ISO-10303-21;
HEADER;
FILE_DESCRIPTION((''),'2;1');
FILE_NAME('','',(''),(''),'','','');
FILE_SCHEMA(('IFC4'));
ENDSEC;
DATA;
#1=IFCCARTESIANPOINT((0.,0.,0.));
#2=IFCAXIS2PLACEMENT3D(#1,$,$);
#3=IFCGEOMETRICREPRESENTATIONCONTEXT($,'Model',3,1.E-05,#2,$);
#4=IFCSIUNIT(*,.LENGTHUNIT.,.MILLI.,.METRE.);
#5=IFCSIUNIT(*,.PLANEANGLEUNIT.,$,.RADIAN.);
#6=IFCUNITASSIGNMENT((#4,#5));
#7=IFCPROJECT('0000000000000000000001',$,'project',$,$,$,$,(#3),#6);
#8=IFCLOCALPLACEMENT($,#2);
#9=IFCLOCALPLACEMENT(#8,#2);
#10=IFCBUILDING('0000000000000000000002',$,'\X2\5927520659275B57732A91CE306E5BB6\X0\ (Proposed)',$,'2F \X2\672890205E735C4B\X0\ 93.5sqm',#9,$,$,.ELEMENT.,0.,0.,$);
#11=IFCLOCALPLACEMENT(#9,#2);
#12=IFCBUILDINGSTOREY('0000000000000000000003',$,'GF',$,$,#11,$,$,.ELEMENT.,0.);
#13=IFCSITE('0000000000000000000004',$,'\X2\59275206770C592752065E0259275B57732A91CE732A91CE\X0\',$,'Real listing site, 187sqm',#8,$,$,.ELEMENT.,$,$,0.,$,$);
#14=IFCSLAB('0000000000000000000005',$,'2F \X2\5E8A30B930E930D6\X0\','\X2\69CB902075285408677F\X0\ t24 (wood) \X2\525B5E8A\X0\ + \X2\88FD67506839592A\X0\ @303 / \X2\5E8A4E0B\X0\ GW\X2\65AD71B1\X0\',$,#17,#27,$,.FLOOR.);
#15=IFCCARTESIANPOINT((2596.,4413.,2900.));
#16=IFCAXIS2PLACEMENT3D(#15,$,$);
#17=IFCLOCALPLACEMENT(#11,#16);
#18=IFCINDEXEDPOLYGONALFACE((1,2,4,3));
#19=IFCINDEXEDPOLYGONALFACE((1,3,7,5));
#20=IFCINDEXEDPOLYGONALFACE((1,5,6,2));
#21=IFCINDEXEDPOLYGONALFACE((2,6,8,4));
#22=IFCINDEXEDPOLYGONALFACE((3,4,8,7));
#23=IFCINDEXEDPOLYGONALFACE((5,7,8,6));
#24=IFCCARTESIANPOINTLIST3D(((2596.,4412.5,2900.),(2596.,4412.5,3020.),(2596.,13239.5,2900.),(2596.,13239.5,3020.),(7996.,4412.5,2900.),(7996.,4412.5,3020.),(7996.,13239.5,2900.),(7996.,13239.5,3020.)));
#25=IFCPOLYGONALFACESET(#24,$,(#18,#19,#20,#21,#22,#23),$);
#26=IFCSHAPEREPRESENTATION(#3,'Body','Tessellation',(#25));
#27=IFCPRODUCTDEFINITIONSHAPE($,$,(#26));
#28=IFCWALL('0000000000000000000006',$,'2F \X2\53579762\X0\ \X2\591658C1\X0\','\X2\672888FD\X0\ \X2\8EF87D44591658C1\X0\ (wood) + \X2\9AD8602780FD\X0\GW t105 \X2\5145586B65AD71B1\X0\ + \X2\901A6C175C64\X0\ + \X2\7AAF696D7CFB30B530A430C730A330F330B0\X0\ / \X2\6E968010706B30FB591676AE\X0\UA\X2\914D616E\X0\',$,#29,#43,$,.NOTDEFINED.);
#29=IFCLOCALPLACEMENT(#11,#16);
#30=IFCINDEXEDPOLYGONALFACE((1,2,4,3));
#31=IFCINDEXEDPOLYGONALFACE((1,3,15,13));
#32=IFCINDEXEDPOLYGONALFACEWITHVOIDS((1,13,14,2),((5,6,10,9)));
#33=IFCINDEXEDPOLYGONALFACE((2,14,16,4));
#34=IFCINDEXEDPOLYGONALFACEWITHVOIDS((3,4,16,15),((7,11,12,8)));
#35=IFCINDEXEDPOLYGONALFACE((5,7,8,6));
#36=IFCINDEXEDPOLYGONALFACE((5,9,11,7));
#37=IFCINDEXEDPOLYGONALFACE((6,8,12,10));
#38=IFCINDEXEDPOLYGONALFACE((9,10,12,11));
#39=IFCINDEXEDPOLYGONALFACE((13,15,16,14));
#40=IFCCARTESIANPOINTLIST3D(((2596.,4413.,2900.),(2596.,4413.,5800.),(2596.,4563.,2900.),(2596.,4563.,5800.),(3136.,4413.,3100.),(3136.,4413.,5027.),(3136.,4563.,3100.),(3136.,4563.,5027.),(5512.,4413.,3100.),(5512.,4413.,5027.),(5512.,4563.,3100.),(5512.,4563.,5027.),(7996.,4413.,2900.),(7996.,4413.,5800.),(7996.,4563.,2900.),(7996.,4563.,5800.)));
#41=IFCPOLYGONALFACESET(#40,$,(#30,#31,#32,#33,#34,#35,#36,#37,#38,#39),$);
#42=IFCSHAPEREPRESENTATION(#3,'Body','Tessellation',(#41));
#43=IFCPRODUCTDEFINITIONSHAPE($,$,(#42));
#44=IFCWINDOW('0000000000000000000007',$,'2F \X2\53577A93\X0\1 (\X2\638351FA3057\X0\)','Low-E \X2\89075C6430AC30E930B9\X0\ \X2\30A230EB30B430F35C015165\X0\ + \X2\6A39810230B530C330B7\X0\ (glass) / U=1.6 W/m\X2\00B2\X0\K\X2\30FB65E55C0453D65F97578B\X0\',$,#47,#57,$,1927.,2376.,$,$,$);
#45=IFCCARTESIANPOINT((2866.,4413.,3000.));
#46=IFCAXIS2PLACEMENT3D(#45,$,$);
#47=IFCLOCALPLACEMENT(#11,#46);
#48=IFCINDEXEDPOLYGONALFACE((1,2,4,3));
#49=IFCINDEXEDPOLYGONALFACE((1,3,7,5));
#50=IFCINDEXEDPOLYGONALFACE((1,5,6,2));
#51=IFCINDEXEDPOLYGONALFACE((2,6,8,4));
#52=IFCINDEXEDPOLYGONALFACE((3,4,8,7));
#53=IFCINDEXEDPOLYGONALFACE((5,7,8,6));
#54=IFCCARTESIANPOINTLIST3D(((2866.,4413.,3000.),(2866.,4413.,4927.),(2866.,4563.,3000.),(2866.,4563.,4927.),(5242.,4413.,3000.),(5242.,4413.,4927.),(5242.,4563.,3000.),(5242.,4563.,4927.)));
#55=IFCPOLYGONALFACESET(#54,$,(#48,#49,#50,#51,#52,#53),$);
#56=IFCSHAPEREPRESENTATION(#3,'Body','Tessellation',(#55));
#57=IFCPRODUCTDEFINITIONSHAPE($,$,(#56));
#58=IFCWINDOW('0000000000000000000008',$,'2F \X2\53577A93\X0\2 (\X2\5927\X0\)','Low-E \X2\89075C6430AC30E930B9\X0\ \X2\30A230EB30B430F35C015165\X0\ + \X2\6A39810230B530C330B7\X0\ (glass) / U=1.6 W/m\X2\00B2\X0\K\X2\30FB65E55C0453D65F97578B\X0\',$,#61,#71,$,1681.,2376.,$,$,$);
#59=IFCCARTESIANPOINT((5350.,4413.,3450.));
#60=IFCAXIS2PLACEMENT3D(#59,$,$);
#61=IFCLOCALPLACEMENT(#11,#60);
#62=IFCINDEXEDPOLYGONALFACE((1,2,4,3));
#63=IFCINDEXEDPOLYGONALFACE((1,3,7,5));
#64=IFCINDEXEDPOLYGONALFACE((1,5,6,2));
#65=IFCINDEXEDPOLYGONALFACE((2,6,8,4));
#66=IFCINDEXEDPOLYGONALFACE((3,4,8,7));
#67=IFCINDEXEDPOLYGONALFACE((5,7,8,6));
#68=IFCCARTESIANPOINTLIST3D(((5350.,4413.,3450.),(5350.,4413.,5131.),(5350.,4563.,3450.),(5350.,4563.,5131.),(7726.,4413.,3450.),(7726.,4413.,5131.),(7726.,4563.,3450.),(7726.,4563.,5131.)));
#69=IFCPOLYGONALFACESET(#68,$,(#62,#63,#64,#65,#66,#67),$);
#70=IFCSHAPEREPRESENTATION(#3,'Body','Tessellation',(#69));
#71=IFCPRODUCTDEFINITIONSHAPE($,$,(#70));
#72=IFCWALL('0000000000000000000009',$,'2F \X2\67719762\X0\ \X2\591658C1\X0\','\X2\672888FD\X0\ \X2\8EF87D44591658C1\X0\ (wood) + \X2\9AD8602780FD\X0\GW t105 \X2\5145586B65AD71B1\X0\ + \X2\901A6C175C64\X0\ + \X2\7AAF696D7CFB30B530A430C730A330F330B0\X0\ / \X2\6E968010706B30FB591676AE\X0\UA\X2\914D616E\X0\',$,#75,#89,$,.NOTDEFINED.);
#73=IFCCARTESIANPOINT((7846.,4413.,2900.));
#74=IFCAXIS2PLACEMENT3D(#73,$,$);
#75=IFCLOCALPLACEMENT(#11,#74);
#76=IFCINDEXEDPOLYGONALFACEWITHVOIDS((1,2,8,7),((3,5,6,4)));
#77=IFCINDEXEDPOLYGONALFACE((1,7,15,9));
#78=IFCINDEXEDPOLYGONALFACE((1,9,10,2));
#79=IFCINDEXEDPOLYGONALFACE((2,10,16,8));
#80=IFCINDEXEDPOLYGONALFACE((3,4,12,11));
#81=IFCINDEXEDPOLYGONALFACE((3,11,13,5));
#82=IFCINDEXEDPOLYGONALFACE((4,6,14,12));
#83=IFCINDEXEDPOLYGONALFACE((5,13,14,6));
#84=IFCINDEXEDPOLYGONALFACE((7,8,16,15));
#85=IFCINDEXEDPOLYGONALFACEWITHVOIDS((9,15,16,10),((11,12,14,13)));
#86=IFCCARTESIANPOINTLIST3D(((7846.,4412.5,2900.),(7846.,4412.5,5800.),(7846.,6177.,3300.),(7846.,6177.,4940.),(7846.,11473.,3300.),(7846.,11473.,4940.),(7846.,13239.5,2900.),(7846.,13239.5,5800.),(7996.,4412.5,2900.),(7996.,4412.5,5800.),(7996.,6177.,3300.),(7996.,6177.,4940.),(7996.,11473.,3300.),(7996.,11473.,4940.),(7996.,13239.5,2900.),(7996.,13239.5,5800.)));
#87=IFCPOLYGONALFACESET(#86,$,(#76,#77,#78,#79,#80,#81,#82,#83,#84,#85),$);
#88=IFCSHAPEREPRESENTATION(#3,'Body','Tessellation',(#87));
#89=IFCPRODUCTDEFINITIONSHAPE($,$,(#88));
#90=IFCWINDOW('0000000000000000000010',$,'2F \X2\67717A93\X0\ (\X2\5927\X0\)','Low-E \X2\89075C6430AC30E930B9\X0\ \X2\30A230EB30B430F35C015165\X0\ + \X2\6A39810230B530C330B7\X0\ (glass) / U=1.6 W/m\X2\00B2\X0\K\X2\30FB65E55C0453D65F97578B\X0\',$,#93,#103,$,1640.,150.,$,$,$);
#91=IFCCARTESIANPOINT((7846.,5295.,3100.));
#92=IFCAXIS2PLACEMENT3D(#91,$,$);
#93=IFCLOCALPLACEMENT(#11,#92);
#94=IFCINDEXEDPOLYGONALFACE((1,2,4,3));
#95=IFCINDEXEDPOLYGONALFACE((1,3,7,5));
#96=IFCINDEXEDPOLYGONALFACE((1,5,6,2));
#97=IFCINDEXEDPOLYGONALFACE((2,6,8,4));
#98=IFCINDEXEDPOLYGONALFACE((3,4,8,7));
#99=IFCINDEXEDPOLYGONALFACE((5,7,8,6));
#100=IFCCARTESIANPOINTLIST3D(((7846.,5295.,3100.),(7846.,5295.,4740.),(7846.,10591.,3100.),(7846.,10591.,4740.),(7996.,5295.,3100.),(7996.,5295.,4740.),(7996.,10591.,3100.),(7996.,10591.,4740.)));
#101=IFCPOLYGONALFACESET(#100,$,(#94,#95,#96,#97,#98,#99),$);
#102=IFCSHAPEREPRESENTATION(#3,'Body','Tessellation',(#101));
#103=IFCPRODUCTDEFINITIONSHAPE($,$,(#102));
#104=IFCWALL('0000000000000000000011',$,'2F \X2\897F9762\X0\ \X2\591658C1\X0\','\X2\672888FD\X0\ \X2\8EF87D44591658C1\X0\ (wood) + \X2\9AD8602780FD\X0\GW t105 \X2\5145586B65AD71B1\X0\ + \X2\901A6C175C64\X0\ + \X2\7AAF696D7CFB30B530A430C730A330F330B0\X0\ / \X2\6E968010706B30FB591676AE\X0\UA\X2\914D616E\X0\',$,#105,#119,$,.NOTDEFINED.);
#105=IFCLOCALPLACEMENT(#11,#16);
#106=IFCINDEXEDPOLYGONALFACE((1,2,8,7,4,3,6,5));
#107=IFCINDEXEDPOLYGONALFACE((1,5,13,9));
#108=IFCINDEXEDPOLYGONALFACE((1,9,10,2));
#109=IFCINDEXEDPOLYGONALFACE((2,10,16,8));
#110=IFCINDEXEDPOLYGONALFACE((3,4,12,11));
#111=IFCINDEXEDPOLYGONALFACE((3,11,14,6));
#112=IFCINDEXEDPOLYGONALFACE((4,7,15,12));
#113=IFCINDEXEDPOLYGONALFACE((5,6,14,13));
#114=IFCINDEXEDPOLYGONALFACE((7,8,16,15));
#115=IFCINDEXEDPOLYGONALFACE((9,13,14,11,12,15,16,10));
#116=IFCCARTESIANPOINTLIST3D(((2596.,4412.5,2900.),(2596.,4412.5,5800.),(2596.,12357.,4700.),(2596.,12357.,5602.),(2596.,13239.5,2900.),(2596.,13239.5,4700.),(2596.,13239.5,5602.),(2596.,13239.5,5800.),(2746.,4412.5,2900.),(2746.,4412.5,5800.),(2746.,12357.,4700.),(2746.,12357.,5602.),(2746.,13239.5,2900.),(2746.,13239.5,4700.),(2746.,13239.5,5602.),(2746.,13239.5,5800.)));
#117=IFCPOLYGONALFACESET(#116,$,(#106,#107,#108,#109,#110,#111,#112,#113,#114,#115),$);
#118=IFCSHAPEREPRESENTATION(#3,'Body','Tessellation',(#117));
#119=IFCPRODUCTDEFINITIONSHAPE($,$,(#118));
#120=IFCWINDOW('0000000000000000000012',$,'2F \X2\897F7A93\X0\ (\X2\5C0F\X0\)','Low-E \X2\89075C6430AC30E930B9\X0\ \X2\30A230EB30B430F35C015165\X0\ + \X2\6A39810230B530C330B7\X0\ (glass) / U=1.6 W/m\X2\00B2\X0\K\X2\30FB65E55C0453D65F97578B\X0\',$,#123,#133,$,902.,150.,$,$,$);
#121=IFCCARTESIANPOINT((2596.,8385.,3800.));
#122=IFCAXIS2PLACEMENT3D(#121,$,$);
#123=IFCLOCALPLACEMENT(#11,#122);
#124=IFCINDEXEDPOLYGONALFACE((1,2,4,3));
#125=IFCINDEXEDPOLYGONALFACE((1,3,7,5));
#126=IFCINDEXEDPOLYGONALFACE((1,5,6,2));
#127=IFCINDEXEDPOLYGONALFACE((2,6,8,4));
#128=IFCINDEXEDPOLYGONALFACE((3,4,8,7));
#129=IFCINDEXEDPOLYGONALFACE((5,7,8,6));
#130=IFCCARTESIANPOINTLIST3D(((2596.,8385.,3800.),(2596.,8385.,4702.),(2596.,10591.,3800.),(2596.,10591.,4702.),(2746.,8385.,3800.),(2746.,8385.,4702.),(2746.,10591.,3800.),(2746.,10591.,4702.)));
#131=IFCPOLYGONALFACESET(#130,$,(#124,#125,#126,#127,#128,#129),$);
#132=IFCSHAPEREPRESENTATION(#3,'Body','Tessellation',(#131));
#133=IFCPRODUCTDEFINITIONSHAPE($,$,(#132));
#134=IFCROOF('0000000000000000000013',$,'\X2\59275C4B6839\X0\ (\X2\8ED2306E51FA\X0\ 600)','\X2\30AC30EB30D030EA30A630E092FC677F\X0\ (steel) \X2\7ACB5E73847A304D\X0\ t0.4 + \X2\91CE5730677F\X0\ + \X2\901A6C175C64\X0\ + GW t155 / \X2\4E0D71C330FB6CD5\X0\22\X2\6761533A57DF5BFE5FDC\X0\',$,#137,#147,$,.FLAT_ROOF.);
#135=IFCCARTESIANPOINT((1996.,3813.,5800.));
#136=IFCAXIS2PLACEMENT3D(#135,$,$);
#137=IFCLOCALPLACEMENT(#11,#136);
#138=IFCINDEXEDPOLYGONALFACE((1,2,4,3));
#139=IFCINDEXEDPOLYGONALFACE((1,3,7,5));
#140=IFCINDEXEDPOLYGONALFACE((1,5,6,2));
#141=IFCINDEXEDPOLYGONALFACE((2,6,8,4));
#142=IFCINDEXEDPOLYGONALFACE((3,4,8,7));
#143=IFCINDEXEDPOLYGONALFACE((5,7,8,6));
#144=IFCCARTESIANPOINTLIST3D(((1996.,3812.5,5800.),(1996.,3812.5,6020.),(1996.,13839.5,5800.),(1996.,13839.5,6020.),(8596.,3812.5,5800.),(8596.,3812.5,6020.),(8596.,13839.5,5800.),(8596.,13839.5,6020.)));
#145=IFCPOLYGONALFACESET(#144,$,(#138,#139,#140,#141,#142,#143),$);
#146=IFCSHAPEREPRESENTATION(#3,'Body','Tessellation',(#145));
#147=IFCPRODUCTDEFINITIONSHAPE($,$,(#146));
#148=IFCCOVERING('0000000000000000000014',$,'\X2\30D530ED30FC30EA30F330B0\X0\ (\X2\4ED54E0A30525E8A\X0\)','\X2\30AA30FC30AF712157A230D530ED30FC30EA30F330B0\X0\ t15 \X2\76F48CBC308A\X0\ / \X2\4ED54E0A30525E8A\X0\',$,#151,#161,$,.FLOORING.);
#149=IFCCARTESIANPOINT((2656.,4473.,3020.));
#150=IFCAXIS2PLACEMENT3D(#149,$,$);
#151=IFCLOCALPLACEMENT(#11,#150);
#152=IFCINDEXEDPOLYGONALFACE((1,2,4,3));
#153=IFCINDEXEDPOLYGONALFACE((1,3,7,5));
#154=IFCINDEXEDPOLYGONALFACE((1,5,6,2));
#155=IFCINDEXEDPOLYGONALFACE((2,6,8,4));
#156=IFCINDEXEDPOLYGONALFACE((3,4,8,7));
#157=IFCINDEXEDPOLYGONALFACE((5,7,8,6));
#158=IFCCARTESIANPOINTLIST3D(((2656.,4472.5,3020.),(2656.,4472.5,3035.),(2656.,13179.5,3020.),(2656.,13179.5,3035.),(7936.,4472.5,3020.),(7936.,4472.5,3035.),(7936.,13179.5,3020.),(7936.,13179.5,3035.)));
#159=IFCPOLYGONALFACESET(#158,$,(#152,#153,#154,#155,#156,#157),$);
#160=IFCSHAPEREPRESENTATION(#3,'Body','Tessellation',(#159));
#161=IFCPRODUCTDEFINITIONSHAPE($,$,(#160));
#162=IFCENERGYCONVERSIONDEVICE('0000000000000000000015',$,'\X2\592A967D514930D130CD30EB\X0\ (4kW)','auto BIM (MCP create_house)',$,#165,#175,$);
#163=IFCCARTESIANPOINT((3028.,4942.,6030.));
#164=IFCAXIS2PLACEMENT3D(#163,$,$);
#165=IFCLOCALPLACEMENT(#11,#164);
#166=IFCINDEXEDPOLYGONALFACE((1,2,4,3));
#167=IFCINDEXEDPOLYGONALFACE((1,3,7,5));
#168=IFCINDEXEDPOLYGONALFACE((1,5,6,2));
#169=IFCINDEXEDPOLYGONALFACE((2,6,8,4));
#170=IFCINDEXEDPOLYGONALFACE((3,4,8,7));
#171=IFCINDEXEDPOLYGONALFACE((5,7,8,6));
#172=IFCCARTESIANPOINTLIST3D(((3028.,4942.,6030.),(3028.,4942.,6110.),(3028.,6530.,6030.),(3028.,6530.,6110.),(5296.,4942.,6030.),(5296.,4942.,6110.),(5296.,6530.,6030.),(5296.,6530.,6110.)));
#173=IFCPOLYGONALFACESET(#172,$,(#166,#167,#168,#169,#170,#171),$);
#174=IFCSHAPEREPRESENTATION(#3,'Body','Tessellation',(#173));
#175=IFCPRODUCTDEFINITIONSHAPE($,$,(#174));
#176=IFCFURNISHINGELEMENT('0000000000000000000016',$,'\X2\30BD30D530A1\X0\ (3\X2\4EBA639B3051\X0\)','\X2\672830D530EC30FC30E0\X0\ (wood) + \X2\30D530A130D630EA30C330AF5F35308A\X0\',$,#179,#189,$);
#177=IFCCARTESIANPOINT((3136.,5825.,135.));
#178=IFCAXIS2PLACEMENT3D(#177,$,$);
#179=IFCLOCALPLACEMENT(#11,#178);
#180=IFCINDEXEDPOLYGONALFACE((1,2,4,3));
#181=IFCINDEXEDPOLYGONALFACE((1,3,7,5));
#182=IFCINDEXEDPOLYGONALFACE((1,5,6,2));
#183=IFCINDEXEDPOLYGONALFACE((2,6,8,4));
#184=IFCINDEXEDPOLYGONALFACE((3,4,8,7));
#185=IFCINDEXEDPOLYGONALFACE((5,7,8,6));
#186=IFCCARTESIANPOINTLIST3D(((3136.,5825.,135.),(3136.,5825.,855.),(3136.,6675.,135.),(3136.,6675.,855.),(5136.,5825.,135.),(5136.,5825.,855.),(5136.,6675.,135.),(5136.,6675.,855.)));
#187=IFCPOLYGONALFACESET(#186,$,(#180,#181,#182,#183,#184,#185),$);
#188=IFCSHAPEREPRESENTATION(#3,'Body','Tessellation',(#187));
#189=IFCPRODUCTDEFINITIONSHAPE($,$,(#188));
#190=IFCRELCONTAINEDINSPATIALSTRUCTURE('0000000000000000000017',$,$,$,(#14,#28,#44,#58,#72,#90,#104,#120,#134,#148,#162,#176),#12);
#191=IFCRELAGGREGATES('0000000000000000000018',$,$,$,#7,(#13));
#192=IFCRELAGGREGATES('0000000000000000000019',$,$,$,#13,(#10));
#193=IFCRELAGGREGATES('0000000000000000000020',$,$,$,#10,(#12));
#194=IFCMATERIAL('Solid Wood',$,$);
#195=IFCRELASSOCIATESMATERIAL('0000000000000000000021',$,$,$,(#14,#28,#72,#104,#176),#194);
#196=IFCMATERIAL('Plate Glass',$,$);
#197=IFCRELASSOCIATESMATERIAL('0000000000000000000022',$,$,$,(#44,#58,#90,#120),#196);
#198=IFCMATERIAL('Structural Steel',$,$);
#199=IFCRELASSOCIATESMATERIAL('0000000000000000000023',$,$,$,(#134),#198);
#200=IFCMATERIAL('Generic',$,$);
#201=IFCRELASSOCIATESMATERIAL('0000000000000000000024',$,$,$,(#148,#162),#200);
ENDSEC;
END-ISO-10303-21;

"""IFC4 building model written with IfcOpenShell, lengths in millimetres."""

from ifc_helpers import new_model, si_unit, frame, frame_2d, origin, place, context, project, spatial, rectangle, extrude, material, element, fill, save


model = new_model("IFC4")

# Units and contexts
model_context = context("Model", 3, precision=1e-05, world=origin())
ifc_project = project(units=[si_unit("LENGTHUNIT", "METRE", prefix="MILLI"), si_unit("PLANEANGLEUNIT", "RADIAN")], contexts=[model_context])

# Site, building, storey
site_placement = place(None, origin())
site = spatial("IfcSite", under=ifc_project, at=site_placement, Name="大分県大分市大字猪野猪野", ObjectType="Real listing site, 187sqm", CompositionType="ELEMENT", RefElevation=0.0)
building_placement = place(site_placement, origin())
building = spatial("IfcBuilding", under=site, at=building_placement, Name="大分大字猪野の家 (Proposed)", ObjectType="2F 木造平屋 93.5sqm", CompositionType="ELEMENT", ElevationOfRefHeight=0.0, ElevationOfTerrain=0.0)
storey_placement = place(building_placement, origin())
storey = spatial("IfcBuildingStorey", under=building, at=storey_placement, Name="GF", CompositionType="ELEMENT", Elevation=0.0)

# Slab
ifc_material_1 = material(Name="Solid Wood")
slab_placement = place(storey_placement, frame((2596.0, 4413.0, 2900.0)))
element("IfcSlab", 1, at=slab_placement, inside=storey, material=ifc_material_1, Name="2F 床スラブ", Description="構造用合板 t24 (wood) 剛床 + 製材根太 @303 / 床下 GW断熱", PredefinedType="FLOOR", context=model_context, shape_type="SweptSolid", body=[
    extrude(rectangle(XDim=5400.0, YDim=8827.0, at=frame_2d((2700.0, 4413.0))), frame((2596.0, 4413.0, 2900.0)), (0.0, 0.0, 1.0), 120.0),
])

# Wall, openings, windows
wall_1_placement = place(storey_placement, frame((2596.0, 4413.0, 2900.0)))
wall_1 = element("IfcWall", 2, at=wall_1_placement, inside=storey, material=ifc_material_1, Name="2F 南面 外壁", Description="木製 軸組外壁 (wood) + 高性能GW t105 充填断熱 + 通気層 + 窯業系サイディング / 準耐火・外皮UA配慮", PredefinedType="NOTDEFINED", context=model_context, shape_type="SweptSolid", body=[
    extrude(rectangle(XDim=5400.0, YDim=150.0, at=frame_2d((2700.0, 75.0))), frame((2596.0, 4413.0, 2900.0)), (0.0, 0.0, 1.0), 2900.0),
])
opening_1_placement = place(storey_placement, frame((2866.0, 4413.0, 3000.0)))
opening_1 = element("IfcOpeningElement", 3, at=opening_1_placement, cuts=wall_1, PredefinedType="NOTDEFINED", context=model_context, shape_type="SweptSolid", body=[
    extrude(rectangle(XDim=2376.0, YDim=150.0, at=frame_2d((1188.0, 75.0))), frame((2866.0, 4413.0, 3000.0)), (0.0, 0.0, 1.0), 1927.0),
])
opening_2_placement = place(storey_placement, frame((5350.0, 4413.0, 3450.0)))
opening_2 = element("IfcOpeningElement", 4, at=opening_2_placement, cuts=wall_1, PredefinedType="NOTDEFINED", context=model_context, shape_type="SweptSolid", body=[
    extrude(rectangle(XDim=2376.0, YDim=150.0, at=frame_2d((1188.0, 75.0))), frame((5350.0, 4413.0, 3450.0)), (0.0, 0.0, 1.0), 1681.0),
])
ifc_material_2 = material(Name="Plate Glass")
window_1_placement = place(storey_placement, frame((2866.0, 4413.0, 3000.0)))
window_1 = element("IfcWindow", 5, at=window_1_placement, inside=storey, material=ifc_material_2, Name="2F 南窓1 (掃出し)", Description="Low-E 複層ガラス アルゴン封入 + 樹脂サッシ (glass) / U=1.6 W/m²K・日射取得型", OverallHeight=1927.0, OverallWidth=2376.0, context=model_context, shape_type="SweptSolid", body=[
    extrude(rectangle(XDim=2376.0, YDim=150.0, at=frame_2d((1188.0, 75.0))), frame((2866.0, 4413.0, 3000.0)), (0.0, 0.0, 1.0), 1927.0),
])
fill(opening_1, window_1)
window_2_placement = place(storey_placement, frame((5350.0, 4413.0, 3450.0)))
window_2 = element("IfcWindow", 6, at=window_2_placement, inside=storey, material=ifc_material_2, Name="2F 南窓2 (大)", Description="Low-E 複層ガラス アルゴン封入 + 樹脂サッシ (glass) / U=1.6 W/m²K・日射取得型", OverallHeight=1681.0, OverallWidth=2376.0, context=model_context, shape_type="SweptSolid", body=[
    extrude(rectangle(XDim=2376.0, YDim=150.0, at=frame_2d((1188.0, 75.0))), frame((5350.0, 4413.0, 3450.0)), (0.0, 0.0, 1.0), 1681.0),
])
fill(opening_2, window_2)

# Walls, openings, windows
wall_2_placement = place(storey_placement, frame((7846.0, 4413.0, 2900.0)))
wall_2 = element("IfcWall", 7, at=wall_2_placement, inside=storey, material=ifc_material_1, Name="2F 東面 外壁", Description="木製 軸組外壁 (wood) + 高性能GW t105 充填断熱 + 通気層 + 窯業系サイディング / 準耐火・外皮UA配慮", PredefinedType="NOTDEFINED", context=model_context, shape_type="SweptSolid", body=[
    extrude(rectangle(XDim=150.0, YDim=8827.0, at=frame_2d((75.0, 4413.0))), frame((7846.0, 4413.0, 2900.0)), (0.0, 0.0, 1.0), 2900.0),
])
opening_3_placement = place(storey_placement, frame((7846.0, 5295.0, 3100.0)))
opening_3 = element("IfcOpeningElement", 8, at=opening_3_placement, cuts=wall_2, PredefinedType="NOTDEFINED", context=model_context, shape_type="SweptSolid", body=[
    extrude(rectangle(XDim=150.0, YDim=5296.0, at=frame_2d((75.0, 2648.0))), frame((7846.0, 5295.0, 3100.0)), (0.0, 0.0, 1.0), 1640.0),
])
window_3_placement = place(storey_placement, frame((7846.0, 5295.0, 3100.0)))
window_3 = element("IfcWindow", 9, at=window_3_placement, inside=storey, material=ifc_material_2, Name="2F 東窓 (大)", Description="Low-E 複層ガラス アルゴン封入 + 樹脂サッシ (glass) / U=1.6 W/m²K・日射取得型", OverallHeight=1640.0, OverallWidth=150.0, context=model_context, shape_type="SweptSolid", body=[
    extrude(rectangle(XDim=150.0, YDim=5296.0, at=frame_2d((75.0, 2648.0))), frame((7846.0, 5295.0, 3100.0)), (0.0, 0.0, 1.0), 1640.0),
])
fill(opening_3, window_3)
wall_3_placement = place(storey_placement, frame((2596.0, 4413.0, 2900.0)))
wall_3 = element("IfcWall", 10, at=wall_3_placement, inside=storey, material=ifc_material_1, Name="2F 西面 外壁", Description="木製 軸組外壁 (wood) + 高性能GW t105 充填断熱 + 通気層 + 窯業系サイディング / 準耐火・外皮UA配慮", PredefinedType="NOTDEFINED", context=model_context, shape_type="SweptSolid", body=[
    extrude(rectangle(XDim=150.0, YDim=8827.0, at=frame_2d((75.0, 4413.0))), frame((2596.0, 4413.0, 2900.0)), (0.0, 0.0, 1.0), 2900.0),
])
opening_4_placement = place(storey_placement, frame((2596.0, 8385.0, 3800.0)))
opening_4 = element("IfcOpeningElement", 11, at=opening_4_placement, cuts=wall_3, PredefinedType="NOTDEFINED", context=model_context, shape_type="SweptSolid", body=[
    extrude(rectangle(XDim=150.0, YDim=2206.0, at=frame_2d((75.0, 1103.0))), frame((2596.0, 8385.0, 3800.0)), (0.0, 0.0, 1.0), 902.0),
])
window_4_placement = place(storey_placement, frame((2596.0, 8385.0, 3800.0)))
window_4 = element("IfcWindow", 12, at=window_4_placement, inside=storey, material=ifc_material_2, Name="2F 西窓 (小)", Description="Low-E 複層ガラス アルゴン封入 + 樹脂サッシ (glass) / U=1.6 W/m²K・日射取得型", OverallHeight=902.0, OverallWidth=150.0, context=model_context, shape_type="SweptSolid", body=[
    extrude(rectangle(XDim=150.0, YDim=2206.0, at=frame_2d((75.0, 1103.0))), frame((2596.0, 8385.0, 3800.0)), (0.0, 0.0, 1.0), 902.0),
])
fill(opening_4, window_4)

# Roof
ifc_material_3 = material(Name="Structural Steel")
roof_placement = place(storey_placement, frame((1996.0, 3813.0, 5800.0)))
element("IfcRoof", 13, at=roof_placement, inside=storey, material=ifc_material_3, Name="大屋根 (軒の出 600)", Description="ガルバリウム鋼板 (steel) 立平葺き t0.4 + 野地板 + 通気層 + GW t155 / 不燃・法22条区域対応", PredefinedType="FLAT_ROOF", context=model_context, shape_type="SweptSolid", body=[
    extrude(rectangle(XDim=6600.0, YDim=10027.0, at=frame_2d((3300.0, 5013.0))), frame((1996.0, 3813.0, 5800.0)), (0.0, 0.0, 1.0), 220.0),
])

# Covering
ifc_material_4 = material(Name="Generic")
covering_placement = place(storey_placement, frame((2656.0, 4473.0, 3020.0)))
element("IfcCovering", 14, at=covering_placement, inside=storey, material=ifc_material_4, Name="フローリング (仕上げ床)", Description="オーク無垢フローリング t15 直貼り / 仕上げ床", PredefinedType="FLOORING", context=model_context, shape_type="SweptSolid", body=[
    extrude(rectangle(XDim=5280.0, YDim=8707.0, at=frame_2d((2640.0, 4353.0))), frame((2656.0, 4473.0, 3020.0)), (0.0, 0.0, 1.0), 15.0),
])

# Energy conversion device
energy_conversion_device_placement = place(storey_placement, frame((3028.0, 4942.0, 6030.0)))
element("IfcEnergyConversionDevice", 15, at=energy_conversion_device_placement, inside=storey, material=ifc_material_4, Name="太陽光パネル (4kW)", Description="auto BIM (MCP create_house)", context=model_context, shape_type="SweptSolid", body=[
    extrude(rectangle(XDim=2268.0, YDim=1588.0, at=frame_2d((1134.0, 794.0))), frame((3028.0, 4942.0, 6030.0)), (0.0, 0.0, 1.0), 80.0),
])

# Furnishing element
furnishing_1_placement = place(storey_placement, frame((3136.0, 5825.0, 135.0)))
element("IfcFurnishingElement", 16, at=furnishing_1_placement, inside=storey, material=ifc_material_1, Name="ソファ (3人掛け)", Description="木フレーム (wood) + ファブリック張り", context=model_context, shape_type="SweptSolid", body=[
    extrude(rectangle(XDim=2000.0, YDim=850.0, at=frame_2d((1000.0, 425.0))), frame((3136.0, 5825.0, 135.0)), (0.0, 0.0, 1.0), 720.0),
])

save(model, "model.ifc")
